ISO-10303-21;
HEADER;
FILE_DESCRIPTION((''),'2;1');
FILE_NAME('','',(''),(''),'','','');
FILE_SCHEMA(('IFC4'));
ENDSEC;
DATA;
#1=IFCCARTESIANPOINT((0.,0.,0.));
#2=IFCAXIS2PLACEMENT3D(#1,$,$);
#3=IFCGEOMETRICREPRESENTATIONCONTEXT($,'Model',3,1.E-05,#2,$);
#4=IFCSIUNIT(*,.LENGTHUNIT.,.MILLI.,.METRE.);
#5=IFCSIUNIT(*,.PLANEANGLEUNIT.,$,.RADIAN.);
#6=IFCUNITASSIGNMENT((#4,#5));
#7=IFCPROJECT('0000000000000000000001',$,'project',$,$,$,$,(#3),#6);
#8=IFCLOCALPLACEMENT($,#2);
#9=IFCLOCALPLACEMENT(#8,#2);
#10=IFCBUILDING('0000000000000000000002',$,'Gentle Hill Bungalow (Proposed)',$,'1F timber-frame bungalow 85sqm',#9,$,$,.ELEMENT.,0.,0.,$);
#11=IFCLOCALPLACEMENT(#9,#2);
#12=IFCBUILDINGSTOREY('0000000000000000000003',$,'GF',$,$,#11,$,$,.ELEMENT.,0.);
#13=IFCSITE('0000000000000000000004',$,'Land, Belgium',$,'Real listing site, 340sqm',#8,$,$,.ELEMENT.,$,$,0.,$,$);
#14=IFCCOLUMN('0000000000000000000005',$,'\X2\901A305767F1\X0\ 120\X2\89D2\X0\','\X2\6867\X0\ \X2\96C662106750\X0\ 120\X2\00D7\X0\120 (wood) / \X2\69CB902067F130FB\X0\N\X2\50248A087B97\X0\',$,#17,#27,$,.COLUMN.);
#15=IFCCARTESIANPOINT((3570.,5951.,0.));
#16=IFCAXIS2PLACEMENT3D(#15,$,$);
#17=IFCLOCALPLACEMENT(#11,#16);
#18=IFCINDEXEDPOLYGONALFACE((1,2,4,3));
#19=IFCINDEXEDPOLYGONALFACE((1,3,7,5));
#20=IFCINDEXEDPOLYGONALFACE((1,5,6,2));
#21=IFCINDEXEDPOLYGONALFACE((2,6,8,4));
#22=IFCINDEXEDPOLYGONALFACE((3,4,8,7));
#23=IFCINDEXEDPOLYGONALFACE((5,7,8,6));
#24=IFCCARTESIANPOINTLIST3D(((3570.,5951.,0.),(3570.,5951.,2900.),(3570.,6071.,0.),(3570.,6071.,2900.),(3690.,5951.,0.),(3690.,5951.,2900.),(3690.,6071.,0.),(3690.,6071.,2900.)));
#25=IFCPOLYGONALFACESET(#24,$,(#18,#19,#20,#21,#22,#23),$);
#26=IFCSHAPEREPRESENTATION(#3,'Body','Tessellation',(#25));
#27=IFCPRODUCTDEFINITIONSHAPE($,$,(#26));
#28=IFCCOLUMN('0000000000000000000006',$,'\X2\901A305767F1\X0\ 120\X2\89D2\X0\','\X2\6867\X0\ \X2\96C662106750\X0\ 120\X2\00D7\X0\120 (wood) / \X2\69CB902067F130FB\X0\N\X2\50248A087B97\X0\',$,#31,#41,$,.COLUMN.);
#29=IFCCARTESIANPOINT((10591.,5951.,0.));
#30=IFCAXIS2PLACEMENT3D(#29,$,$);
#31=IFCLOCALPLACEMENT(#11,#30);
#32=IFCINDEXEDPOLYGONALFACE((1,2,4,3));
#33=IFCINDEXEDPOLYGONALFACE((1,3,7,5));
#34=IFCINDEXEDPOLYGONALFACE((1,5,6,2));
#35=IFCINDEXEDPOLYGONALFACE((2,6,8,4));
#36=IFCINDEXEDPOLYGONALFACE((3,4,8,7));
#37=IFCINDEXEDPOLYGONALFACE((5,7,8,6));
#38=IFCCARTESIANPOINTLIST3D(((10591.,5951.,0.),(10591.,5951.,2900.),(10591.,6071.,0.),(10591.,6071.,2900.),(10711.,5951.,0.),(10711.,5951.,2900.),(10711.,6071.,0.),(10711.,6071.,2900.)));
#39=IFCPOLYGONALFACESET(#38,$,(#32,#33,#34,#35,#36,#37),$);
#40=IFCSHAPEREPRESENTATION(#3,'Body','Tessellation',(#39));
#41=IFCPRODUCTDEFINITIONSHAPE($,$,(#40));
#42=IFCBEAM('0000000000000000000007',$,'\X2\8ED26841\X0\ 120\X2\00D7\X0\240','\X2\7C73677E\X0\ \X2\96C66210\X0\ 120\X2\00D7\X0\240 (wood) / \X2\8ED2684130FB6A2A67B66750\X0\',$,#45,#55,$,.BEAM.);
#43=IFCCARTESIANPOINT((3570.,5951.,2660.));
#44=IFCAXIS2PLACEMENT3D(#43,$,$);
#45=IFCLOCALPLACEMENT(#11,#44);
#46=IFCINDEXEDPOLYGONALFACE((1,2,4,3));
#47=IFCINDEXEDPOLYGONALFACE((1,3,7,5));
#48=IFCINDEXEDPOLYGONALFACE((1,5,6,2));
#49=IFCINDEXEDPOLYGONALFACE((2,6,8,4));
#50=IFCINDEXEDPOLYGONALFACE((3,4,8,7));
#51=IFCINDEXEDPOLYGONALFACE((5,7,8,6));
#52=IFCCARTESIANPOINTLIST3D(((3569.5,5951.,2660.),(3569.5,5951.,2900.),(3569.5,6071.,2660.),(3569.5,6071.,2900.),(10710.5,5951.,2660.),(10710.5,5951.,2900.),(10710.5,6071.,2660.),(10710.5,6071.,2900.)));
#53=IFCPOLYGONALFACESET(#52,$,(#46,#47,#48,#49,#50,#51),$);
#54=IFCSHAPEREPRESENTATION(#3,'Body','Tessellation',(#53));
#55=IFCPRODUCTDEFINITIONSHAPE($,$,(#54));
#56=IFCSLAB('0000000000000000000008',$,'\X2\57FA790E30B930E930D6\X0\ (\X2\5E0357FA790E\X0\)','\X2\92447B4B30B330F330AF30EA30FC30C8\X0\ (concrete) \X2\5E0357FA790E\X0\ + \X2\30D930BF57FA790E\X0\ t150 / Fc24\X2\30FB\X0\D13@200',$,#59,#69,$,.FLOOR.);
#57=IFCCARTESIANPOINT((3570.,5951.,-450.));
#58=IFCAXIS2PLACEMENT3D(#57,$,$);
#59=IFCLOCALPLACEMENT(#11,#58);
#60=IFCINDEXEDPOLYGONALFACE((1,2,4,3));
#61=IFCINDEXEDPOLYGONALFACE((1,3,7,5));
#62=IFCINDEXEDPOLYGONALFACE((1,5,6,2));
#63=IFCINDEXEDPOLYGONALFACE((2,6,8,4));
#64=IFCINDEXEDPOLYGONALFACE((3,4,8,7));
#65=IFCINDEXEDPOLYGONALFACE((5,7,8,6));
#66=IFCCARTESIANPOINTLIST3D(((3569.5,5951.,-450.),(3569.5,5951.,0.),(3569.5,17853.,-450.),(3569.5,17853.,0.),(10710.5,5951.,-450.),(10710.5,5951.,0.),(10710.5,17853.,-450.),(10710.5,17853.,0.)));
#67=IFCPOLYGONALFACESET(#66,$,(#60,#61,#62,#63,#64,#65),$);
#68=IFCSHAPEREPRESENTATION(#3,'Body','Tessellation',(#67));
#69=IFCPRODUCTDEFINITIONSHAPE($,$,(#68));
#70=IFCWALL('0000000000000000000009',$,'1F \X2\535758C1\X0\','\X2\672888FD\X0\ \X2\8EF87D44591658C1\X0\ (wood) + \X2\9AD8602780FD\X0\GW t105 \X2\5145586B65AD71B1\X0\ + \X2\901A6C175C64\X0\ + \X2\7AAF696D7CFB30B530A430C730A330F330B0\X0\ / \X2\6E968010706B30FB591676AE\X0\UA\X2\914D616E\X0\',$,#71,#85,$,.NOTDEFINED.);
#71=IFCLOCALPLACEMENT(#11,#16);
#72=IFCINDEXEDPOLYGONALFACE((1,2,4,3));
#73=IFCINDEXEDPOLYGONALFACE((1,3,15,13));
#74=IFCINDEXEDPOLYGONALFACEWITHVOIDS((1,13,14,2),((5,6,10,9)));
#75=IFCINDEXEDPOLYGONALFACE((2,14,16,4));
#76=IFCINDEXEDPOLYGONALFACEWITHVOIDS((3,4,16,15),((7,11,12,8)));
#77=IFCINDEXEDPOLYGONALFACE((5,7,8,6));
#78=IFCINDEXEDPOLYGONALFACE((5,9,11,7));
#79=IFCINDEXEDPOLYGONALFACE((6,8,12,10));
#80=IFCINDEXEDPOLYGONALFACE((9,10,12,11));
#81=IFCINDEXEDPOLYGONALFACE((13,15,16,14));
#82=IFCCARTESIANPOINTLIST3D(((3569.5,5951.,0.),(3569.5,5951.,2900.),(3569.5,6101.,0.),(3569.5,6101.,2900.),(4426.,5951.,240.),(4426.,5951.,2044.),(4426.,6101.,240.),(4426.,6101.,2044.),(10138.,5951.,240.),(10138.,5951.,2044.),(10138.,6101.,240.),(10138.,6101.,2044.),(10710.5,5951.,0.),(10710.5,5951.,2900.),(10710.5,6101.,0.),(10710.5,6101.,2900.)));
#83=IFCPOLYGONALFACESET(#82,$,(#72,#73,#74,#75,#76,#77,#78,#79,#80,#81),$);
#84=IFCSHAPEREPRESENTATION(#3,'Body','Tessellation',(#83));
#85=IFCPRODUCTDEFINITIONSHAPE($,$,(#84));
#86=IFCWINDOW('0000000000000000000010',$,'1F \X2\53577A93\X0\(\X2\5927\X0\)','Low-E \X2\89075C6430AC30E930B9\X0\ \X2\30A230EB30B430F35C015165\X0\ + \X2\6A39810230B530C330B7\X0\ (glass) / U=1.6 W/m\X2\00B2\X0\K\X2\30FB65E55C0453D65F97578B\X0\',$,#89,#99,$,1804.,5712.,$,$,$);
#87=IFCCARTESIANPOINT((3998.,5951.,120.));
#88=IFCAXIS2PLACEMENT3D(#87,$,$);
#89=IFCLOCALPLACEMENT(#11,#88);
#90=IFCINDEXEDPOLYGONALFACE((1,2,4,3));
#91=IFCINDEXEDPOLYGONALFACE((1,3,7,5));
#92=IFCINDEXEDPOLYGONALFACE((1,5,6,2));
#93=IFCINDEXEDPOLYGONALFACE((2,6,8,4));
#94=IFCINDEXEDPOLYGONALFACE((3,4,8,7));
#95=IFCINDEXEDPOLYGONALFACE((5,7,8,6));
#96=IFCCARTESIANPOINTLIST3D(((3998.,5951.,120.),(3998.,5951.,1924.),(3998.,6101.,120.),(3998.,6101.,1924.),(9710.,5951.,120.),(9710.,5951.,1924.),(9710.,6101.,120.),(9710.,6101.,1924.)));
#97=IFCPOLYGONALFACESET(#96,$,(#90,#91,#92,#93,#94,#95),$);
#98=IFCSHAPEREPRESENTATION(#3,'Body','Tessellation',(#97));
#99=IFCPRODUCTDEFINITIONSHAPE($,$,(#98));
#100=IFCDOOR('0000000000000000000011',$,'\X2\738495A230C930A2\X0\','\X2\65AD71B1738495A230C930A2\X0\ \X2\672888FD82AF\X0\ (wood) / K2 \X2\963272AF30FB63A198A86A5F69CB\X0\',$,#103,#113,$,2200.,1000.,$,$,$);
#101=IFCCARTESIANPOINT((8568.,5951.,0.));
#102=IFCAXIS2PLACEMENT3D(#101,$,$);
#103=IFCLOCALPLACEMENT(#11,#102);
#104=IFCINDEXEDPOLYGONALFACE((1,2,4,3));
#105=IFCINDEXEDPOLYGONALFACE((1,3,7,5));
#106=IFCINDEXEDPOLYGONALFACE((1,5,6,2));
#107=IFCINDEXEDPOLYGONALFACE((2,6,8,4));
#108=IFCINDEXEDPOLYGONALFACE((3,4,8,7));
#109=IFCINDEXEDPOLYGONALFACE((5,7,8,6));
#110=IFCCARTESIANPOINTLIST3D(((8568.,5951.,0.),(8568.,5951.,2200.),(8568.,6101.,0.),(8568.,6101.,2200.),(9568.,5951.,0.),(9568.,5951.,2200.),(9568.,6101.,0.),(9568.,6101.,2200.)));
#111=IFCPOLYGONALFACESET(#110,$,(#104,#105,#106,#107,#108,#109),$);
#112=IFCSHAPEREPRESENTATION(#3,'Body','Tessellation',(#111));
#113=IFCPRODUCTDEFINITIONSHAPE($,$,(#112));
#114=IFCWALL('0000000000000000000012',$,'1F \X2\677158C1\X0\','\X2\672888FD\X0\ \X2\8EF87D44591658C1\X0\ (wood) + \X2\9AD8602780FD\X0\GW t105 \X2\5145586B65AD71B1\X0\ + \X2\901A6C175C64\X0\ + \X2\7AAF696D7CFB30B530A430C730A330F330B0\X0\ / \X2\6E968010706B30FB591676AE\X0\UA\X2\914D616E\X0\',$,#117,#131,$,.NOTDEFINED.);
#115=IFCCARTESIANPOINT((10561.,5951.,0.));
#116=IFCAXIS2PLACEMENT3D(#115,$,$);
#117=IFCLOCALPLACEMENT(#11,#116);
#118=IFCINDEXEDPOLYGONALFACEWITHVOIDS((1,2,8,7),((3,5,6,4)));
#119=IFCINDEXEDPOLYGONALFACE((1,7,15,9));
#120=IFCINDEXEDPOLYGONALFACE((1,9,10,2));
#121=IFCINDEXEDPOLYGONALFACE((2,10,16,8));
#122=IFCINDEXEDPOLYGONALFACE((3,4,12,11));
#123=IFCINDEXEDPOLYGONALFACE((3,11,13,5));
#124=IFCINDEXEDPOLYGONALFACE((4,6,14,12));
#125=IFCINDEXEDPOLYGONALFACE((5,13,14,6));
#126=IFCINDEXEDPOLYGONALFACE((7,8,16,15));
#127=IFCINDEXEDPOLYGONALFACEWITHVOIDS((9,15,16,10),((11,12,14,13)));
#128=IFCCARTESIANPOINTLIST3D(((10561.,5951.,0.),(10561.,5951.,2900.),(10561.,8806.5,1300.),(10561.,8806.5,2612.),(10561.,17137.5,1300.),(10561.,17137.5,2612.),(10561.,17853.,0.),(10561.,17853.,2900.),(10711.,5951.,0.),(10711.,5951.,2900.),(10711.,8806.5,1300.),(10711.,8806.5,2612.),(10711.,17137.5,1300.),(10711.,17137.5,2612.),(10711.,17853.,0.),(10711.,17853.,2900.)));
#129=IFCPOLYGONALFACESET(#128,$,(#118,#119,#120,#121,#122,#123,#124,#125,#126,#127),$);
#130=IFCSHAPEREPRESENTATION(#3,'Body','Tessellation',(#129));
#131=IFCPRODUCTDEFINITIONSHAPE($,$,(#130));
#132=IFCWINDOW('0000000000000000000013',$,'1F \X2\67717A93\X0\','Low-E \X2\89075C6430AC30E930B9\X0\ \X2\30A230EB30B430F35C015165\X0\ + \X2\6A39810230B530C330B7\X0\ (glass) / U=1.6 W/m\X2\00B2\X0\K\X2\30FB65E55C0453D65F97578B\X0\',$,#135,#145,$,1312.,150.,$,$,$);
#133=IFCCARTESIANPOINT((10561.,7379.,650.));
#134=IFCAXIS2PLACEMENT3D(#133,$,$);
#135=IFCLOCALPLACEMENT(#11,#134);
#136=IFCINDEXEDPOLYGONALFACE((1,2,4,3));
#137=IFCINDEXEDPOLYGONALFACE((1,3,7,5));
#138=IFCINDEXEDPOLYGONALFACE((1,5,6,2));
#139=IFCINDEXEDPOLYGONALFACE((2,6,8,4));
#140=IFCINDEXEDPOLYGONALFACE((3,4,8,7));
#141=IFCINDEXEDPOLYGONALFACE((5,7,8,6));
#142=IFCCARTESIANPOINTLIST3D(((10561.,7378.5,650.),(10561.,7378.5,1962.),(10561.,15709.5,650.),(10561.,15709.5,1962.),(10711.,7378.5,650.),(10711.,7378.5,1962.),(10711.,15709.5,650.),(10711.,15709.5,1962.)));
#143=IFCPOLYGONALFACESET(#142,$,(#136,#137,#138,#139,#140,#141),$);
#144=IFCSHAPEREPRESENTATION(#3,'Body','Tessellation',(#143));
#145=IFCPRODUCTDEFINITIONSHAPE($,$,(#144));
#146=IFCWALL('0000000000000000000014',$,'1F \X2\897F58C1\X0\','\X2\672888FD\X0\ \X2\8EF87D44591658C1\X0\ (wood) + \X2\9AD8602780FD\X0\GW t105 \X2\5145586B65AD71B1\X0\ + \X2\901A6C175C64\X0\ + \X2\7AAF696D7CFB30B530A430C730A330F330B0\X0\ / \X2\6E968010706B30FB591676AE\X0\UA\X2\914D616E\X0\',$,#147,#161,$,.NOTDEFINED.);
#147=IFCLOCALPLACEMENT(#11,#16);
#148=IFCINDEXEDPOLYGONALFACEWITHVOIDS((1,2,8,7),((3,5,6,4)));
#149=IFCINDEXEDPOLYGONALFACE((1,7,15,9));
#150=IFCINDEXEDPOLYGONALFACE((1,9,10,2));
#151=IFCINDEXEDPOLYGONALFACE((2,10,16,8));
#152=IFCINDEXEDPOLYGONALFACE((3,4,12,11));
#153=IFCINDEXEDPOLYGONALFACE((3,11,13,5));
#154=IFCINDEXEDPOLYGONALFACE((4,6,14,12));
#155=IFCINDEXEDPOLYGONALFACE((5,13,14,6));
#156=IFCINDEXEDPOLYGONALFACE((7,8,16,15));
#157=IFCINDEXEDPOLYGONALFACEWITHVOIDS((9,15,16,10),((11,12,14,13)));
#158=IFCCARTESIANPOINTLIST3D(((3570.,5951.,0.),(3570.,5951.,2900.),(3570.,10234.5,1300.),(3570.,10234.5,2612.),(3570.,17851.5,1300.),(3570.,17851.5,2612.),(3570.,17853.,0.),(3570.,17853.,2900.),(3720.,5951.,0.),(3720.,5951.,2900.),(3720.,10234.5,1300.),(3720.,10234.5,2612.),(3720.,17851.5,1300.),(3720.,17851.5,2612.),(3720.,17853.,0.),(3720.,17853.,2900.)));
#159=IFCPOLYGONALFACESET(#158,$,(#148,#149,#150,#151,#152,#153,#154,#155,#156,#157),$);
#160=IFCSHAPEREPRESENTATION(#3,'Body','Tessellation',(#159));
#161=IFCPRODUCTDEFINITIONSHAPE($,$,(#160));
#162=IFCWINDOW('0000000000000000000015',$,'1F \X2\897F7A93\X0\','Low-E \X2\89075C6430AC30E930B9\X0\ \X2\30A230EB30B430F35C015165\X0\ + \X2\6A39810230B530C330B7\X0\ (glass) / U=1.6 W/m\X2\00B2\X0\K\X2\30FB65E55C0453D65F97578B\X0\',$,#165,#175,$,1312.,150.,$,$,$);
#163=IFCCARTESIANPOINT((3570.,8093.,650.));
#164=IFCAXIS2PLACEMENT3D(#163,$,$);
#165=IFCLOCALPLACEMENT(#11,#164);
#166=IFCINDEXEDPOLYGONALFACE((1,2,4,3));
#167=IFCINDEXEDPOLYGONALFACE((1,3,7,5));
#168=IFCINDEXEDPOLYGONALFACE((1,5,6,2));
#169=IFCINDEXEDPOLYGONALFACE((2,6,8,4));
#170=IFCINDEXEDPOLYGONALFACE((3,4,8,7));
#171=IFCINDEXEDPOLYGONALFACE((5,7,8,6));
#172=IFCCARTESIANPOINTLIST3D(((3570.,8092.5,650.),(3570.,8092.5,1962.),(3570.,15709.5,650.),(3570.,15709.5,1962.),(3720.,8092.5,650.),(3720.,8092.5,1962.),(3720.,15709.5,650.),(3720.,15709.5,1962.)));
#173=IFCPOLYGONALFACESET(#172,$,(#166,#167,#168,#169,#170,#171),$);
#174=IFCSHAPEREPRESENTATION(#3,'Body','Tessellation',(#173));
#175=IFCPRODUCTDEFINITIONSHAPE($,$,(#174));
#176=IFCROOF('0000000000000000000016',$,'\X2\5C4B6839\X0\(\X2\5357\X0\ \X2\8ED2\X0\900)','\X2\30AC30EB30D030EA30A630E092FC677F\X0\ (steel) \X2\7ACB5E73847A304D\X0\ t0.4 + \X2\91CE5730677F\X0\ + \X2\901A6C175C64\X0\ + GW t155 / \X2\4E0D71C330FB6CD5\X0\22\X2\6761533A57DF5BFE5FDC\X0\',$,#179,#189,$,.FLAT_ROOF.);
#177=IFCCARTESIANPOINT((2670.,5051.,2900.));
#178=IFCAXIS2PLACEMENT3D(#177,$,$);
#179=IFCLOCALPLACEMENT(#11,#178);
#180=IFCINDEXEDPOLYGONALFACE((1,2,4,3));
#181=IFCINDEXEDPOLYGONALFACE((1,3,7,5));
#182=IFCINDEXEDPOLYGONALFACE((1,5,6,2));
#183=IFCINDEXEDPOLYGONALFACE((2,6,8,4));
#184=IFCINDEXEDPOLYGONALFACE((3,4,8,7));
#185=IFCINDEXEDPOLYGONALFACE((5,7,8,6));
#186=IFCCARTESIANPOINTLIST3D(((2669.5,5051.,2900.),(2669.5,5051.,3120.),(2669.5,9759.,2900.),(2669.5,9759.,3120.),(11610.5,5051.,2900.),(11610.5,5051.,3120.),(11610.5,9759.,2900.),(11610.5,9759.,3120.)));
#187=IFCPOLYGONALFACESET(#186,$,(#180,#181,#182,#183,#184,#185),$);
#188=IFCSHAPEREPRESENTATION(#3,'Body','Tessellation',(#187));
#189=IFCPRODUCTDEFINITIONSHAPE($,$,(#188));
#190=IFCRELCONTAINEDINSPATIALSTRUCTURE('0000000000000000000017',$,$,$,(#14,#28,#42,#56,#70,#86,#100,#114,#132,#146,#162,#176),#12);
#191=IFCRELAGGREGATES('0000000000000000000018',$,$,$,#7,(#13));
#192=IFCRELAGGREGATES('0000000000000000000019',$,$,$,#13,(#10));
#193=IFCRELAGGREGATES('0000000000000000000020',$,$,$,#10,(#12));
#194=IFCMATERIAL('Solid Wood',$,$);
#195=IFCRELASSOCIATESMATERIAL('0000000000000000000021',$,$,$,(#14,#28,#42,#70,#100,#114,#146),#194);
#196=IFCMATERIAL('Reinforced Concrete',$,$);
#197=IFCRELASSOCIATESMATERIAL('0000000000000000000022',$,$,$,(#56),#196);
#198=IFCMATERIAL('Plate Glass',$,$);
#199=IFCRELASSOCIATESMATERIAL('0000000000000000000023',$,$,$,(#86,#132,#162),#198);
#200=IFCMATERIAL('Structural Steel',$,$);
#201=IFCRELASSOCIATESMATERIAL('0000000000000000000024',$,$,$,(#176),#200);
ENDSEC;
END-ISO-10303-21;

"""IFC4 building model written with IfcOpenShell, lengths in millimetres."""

from ifc_helpers import new_model, si_unit, frame, frame_2d, origin, place, context, project, spatial, rectangle, extrude, material, element, fill, save


model = new_model("IFC4")

# Units and contexts
model_context = context("Model", 3, precision=1e-05, world=origin())
ifc_project = project(units=[si_unit("LENGTHUNIT", "METRE", prefix="MILLI"), si_unit("PLANEANGLEUNIT", "RADIAN")], contexts=[model_context])

# Site, building, storey
site_placement = place(None, origin())
site = spatial("IfcSite", under=ifc_project, at=site_placement, Name="Land, Belgium", ObjectType="Real listing site, 340sqm", CompositionType="ELEMENT", RefElevation=0.0)
building_placement = place(site_placement, origin())
building = spatial("IfcBuilding", under=site, at=building_placement, Name="Gentle Hill Bungalow (Proposed)", ObjectType="1F timber-frame bungalow 85sqm", CompositionType="ELEMENT", ElevationOfRefHeight=0.0, ElevationOfTerrain=0.0)
storey_placement = place(building_placement, origin())
storey = spatial("IfcBuildingStorey", under=building, at=storey_placement, Name="GF", CompositionType="ELEMENT", Elevation=0.0)

# Columns
ifc_material_1 = material(Name="Solid Wood")
column_1_placement = place(storey_placement, frame((3570.0, 5951.0, 0.0)))
element("IfcColumn", 1, at=column_1_placement, inside=storey, material=ifc_material_1, Name="通し柱 120角", Description="桧 集成材 120×120 (wood) / 構造柱・N値計算", PredefinedType="COLUMN", context=model_context, shape_type="SweptSolid", body=[
    extrude(rectangle(XDim=120.0, YDim=120.0, at=frame_2d((60.0, 60.0))), frame((3570.0, 5951.0, 0.0)), (0.0, 0.0, 1.0), 2900.0),
])
column_2_placement = place(storey_placement, frame((10591.0, 5951.0, 0.0)))
element("IfcColumn", 2, at=column_2_placement, inside=storey, material=ifc_material_1, Name="通し柱 120角", Description="桧 集成材 120×120 (wood) / 構造柱・N値計算", PredefinedType="COLUMN", context=model_context, shape_type="SweptSolid", body=[
    extrude(rectangle(XDim=120.0, YDim=120.0, at=frame_2d((60.0, 60.0))), frame((10591.0, 5951.0, 0.0)), (0.0, 0.0, 1.0), 2900.0),
])

# Beam
beam_1_placement = place(storey_placement, frame((3570.0, 5951.0, 2660.0)))
element("IfcBeam", 3, at=beam_1_placement, inside=storey, material=ifc_material_1, Name="軒桁 120×240", Description="米松 集成 120×240 (wood) / 軒桁・横架材", PredefinedType="BEAM", context=model_context, shape_type="SweptSolid", body=[
    extrude(rectangle(XDim=7141.0, YDim=120.0, at=frame_2d((3570.0, 60.0))), frame((3570.0, 5951.0, 2660.0)), (0.0, 0.0, 1.0), 240.0),
])

# Slab
ifc_material_2 = material(Name="Reinforced Concrete")
slab_1_placement = place(storey_placement, frame((3570.0, 5951.0, -450.0)))
element("IfcSlab", 4, at=slab_1_placement, inside=storey, material=ifc_material_2, Name="基礎スラブ (布基礎)", Description="鉄筋コンクリート (concrete) 布基礎 + ベタ基礎 t150 / Fc24・D13@200", PredefinedType="FLOOR", context=model_context, shape_type="SweptSolid", body=[
    extrude(rectangle(XDim=7141.0, YDim=11902.0, at=frame_2d((3570.0, 5951.0))), frame((3570.0, 5951.0, -450.0)), (0.0, 0.0, 1.0), 450.0),
])

# Wall, openings, window, door
wall_1_placement = place(storey_placement, frame((3570.0, 5951.0, 0.0)))
wall_1 = element("IfcWall", 5, at=wall_1_placement, inside=storey, material=ifc_material_1, Name="1F 南壁", Description="木製 軸組外壁 (wood) + 高性能GW t105 充填断熱 + 通気層 + 窯業系サイディング / 準耐火・外皮UA配慮", PredefinedType="NOTDEFINED", context=model_context, shape_type="SweptSolid", body=[
    extrude(rectangle(XDim=7141.0, YDim=150.0, at=frame_2d((3570.0, 75.0))), frame((3570.0, 5951.0, 0.0)), (0.0, 0.0, 1.0), 2900.0),
])
opening_1_placement = place(storey_placement, frame((3998.0, 5951.0, 120.0)))
opening_1 = element("IfcOpeningElement", 6, at=opening_1_placement, cuts=wall_1, PredefinedType="NOTDEFINED", context=model_context, shape_type="SweptSolid", body=[
    extrude(rectangle(XDim=5712.0, YDim=150.0, at=frame_2d((2856.0, 75.0))), frame((3998.0, 5951.0, 120.0)), (0.0, 0.0, 1.0), 1804.0),
])
opening_2_placement = place(storey_placement, frame((8568.0, 5951.0, 0.0)))
opening_2 = element("IfcOpeningElement", 7, at=opening_2_placement, cuts=wall_1, PredefinedType="NOTDEFINED", context=model_context, shape_type="SweptSolid", body=[
    extrude(rectangle(XDim=1000.0, YDim=150.0, at=frame_2d((500.0, 75.0))), frame((8568.0, 5951.0, 0.0)), (0.0, 0.0, 1.0), 2200.0),
])
ifc_material_3 = material(Name="Plate Glass")
window_1_placement = place(storey_placement, frame((3998.0, 5951.0, 120.0)))
window_1 = element("IfcWindow", 8, at=window_1_placement, inside=storey, material=ifc_material_3, Name="1F 南窓(大)", Description="Low-E 複層ガラス アルゴン封入 + 樹脂サッシ (glass) / U=1.6 W/m²K・日射取得型", OverallHeight=1804.0, OverallWidth=5712.0, context=model_context, shape_type="SweptSolid", body=[
    extrude(rectangle(XDim=5712.0, YDim=150.0, at=frame_2d((2856.0, 75.0))), frame((3998.0, 5951.0, 120.0)), (0.0, 0.0, 1.0), 1804.0),
])
fill(opening_1, window_1)
door_placement = place(storey_placement, frame((8568.0, 5951.0, 0.0)))
door = element("IfcDoor", 9, at=door_placement, inside=storey, material=ifc_material_1, Name="玄関ドア", Description="断熱玄関ドア 木製芯 (wood) / K2 防犯・採風機構", OverallHeight=2200.0, OverallWidth=1000.0, context=model_context, shape_type="SweptSolid", body=[
    extrude(rectangle(XDim=1000.0, YDim=150.0, at=frame_2d((500.0, 75.0))), frame((8568.0, 5951.0, 0.0)), (0.0, 0.0, 1.0), 2200.0),
])
fill(opening_2, door)

# Walls, openings, windows
wall_2_placement = place(storey_placement, frame((10561.0, 5951.0, 0.0)))
wall_2 = element("IfcWall", 10, at=wall_2_placement, inside=storey, material=ifc_material_1, Name="1F 東壁", Description="木製 軸組外壁 (wood) + 高性能GW t105 充填断熱 + 通気層 + 窯業系サイディング / 準耐火・外皮UA配慮", PredefinedType="NOTDEFINED", context=model_context, shape_type="SweptSolid", body=[
    extrude(rectangle(XDim=150.0, YDim=11902.0, at=frame_2d((75.0, 5951.0))), frame((10561.0, 5951.0, 0.0)), (0.0, 0.0, 1.0), 2900.0),
])
opening_3_placement = place(storey_placement, frame((10561.0, 7379.0, 650.0)))
opening_3 = element("IfcOpeningElement", 11, at=opening_3_placement, cuts=wall_2, PredefinedType="NOTDEFINED", context=model_context, shape_type="SweptSolid", body=[
    extrude(rectangle(XDim=150.0, YDim=8331.0, at=frame_2d((75.0, 4165.0))), frame((10561.0, 7379.0, 650.0)), (0.0, 0.0, 1.0), 1312.0),
])
window_2_placement = place(storey_placement, frame((10561.0, 7379.0, 650.0)))
window_2 = element("IfcWindow", 12, at=window_2_placement, inside=storey, material=ifc_material_3, Name="1F 東窓", Description="Low-E 複層ガラス アルゴン封入 + 樹脂サッシ (glass) / U=1.6 W/m²K・日射取得型", OverallHeight=1312.0, OverallWidth=150.0, context=model_context, shape_type="SweptSolid", body=[
    extrude(rectangle(XDim=150.0, YDim=8331.0, at=frame_2d((75.0, 4165.0))), frame((10561.0, 7379.0, 650.0)), (0.0, 0.0, 1.0), 1312.0),
])
fill(opening_3, window_2)
wall_3_placement = place(storey_placement, frame((3570.0, 5951.0, 0.0)))
wall_3 = element("IfcWall", 13, at=wall_3_placement, inside=storey, material=ifc_material_1, Name="1F 西壁", Description="木製 軸組外壁 (wood) + 高性能GW t105 充填断熱 + 通気層 + 窯業系サイディング / 準耐火・外皮UA配慮", PredefinedType="NOTDEFINED", context=model_context, shape_type="SweptSolid", body=[
    extrude(rectangle(XDim=150.0, YDim=11902.0, at=frame_2d((75.0, 5951.0))), frame((3570.0, 5951.0, 0.0)), (0.0, 0.0, 1.0), 2900.0),
])
opening_4_placement = place(storey_placement, frame((3570.0, 8093.0, 650.0)))
opening_4 = element("IfcOpeningElement", 14, at=opening_4_placement, cuts=wall_3, PredefinedType="NOTDEFINED", context=model_context, shape_type="SweptSolid", body=[
    extrude(rectangle(XDim=150.0, YDim=7617.0, at=frame_2d((75.0, 3808.0))), frame((3570.0, 8093.0, 650.0)), (0.0, 0.0, 1.0), 1312.0),
])
window_3_placement = place(storey_placement, frame((3570.0, 8093.0, 650.0)))
window_3 = element("IfcWindow", 15, at=window_3_placement, inside=storey, material=ifc_material_3, Name="1F 西窓", Description="Low-E 複層ガラス アルゴン封入 + 樹脂サッシ (glass) / U=1.6 W/m²K・日射取得型", OverallHeight=1312.0, OverallWidth=150.0, context=model_context, shape_type="SweptSolid", body=[
    extrude(rectangle(XDim=150.0, YDim=7617.0, at=frame_2d((75.0, 3808.0))), frame((3570.0, 8093.0, 650.0)), (0.0, 0.0, 1.0), 1312.0),
])
fill(opening_4, window_3)

# Roof
ifc_material_4 = material(Name="Structural Steel")
roof_placement = place(storey_placement, frame((2670.0, 5051.0, 2900.0)))
element("IfcRoof", 16, at=roof_placement, inside=storey, material=ifc_material_4, Name="屋根(南 軒900)", Description="ガルバリウム鋼板 (steel) 立平葺き t0.4 + 野地板 + 通気層 + GW t155 / 不燃・法22条区域対応", PredefinedType="FLAT_ROOF", context=model_context, shape_type="SweptSolid", body=[
    extrude(rectangle(XDim=8941.0, YDim=4708.0, at=frame_2d((4470.0, 2354.0))), frame((2670.0, 5051.0, 2900.0)), (0.0, 0.0, 1.0), 220.0),
])

save(model, "model.ifc")
